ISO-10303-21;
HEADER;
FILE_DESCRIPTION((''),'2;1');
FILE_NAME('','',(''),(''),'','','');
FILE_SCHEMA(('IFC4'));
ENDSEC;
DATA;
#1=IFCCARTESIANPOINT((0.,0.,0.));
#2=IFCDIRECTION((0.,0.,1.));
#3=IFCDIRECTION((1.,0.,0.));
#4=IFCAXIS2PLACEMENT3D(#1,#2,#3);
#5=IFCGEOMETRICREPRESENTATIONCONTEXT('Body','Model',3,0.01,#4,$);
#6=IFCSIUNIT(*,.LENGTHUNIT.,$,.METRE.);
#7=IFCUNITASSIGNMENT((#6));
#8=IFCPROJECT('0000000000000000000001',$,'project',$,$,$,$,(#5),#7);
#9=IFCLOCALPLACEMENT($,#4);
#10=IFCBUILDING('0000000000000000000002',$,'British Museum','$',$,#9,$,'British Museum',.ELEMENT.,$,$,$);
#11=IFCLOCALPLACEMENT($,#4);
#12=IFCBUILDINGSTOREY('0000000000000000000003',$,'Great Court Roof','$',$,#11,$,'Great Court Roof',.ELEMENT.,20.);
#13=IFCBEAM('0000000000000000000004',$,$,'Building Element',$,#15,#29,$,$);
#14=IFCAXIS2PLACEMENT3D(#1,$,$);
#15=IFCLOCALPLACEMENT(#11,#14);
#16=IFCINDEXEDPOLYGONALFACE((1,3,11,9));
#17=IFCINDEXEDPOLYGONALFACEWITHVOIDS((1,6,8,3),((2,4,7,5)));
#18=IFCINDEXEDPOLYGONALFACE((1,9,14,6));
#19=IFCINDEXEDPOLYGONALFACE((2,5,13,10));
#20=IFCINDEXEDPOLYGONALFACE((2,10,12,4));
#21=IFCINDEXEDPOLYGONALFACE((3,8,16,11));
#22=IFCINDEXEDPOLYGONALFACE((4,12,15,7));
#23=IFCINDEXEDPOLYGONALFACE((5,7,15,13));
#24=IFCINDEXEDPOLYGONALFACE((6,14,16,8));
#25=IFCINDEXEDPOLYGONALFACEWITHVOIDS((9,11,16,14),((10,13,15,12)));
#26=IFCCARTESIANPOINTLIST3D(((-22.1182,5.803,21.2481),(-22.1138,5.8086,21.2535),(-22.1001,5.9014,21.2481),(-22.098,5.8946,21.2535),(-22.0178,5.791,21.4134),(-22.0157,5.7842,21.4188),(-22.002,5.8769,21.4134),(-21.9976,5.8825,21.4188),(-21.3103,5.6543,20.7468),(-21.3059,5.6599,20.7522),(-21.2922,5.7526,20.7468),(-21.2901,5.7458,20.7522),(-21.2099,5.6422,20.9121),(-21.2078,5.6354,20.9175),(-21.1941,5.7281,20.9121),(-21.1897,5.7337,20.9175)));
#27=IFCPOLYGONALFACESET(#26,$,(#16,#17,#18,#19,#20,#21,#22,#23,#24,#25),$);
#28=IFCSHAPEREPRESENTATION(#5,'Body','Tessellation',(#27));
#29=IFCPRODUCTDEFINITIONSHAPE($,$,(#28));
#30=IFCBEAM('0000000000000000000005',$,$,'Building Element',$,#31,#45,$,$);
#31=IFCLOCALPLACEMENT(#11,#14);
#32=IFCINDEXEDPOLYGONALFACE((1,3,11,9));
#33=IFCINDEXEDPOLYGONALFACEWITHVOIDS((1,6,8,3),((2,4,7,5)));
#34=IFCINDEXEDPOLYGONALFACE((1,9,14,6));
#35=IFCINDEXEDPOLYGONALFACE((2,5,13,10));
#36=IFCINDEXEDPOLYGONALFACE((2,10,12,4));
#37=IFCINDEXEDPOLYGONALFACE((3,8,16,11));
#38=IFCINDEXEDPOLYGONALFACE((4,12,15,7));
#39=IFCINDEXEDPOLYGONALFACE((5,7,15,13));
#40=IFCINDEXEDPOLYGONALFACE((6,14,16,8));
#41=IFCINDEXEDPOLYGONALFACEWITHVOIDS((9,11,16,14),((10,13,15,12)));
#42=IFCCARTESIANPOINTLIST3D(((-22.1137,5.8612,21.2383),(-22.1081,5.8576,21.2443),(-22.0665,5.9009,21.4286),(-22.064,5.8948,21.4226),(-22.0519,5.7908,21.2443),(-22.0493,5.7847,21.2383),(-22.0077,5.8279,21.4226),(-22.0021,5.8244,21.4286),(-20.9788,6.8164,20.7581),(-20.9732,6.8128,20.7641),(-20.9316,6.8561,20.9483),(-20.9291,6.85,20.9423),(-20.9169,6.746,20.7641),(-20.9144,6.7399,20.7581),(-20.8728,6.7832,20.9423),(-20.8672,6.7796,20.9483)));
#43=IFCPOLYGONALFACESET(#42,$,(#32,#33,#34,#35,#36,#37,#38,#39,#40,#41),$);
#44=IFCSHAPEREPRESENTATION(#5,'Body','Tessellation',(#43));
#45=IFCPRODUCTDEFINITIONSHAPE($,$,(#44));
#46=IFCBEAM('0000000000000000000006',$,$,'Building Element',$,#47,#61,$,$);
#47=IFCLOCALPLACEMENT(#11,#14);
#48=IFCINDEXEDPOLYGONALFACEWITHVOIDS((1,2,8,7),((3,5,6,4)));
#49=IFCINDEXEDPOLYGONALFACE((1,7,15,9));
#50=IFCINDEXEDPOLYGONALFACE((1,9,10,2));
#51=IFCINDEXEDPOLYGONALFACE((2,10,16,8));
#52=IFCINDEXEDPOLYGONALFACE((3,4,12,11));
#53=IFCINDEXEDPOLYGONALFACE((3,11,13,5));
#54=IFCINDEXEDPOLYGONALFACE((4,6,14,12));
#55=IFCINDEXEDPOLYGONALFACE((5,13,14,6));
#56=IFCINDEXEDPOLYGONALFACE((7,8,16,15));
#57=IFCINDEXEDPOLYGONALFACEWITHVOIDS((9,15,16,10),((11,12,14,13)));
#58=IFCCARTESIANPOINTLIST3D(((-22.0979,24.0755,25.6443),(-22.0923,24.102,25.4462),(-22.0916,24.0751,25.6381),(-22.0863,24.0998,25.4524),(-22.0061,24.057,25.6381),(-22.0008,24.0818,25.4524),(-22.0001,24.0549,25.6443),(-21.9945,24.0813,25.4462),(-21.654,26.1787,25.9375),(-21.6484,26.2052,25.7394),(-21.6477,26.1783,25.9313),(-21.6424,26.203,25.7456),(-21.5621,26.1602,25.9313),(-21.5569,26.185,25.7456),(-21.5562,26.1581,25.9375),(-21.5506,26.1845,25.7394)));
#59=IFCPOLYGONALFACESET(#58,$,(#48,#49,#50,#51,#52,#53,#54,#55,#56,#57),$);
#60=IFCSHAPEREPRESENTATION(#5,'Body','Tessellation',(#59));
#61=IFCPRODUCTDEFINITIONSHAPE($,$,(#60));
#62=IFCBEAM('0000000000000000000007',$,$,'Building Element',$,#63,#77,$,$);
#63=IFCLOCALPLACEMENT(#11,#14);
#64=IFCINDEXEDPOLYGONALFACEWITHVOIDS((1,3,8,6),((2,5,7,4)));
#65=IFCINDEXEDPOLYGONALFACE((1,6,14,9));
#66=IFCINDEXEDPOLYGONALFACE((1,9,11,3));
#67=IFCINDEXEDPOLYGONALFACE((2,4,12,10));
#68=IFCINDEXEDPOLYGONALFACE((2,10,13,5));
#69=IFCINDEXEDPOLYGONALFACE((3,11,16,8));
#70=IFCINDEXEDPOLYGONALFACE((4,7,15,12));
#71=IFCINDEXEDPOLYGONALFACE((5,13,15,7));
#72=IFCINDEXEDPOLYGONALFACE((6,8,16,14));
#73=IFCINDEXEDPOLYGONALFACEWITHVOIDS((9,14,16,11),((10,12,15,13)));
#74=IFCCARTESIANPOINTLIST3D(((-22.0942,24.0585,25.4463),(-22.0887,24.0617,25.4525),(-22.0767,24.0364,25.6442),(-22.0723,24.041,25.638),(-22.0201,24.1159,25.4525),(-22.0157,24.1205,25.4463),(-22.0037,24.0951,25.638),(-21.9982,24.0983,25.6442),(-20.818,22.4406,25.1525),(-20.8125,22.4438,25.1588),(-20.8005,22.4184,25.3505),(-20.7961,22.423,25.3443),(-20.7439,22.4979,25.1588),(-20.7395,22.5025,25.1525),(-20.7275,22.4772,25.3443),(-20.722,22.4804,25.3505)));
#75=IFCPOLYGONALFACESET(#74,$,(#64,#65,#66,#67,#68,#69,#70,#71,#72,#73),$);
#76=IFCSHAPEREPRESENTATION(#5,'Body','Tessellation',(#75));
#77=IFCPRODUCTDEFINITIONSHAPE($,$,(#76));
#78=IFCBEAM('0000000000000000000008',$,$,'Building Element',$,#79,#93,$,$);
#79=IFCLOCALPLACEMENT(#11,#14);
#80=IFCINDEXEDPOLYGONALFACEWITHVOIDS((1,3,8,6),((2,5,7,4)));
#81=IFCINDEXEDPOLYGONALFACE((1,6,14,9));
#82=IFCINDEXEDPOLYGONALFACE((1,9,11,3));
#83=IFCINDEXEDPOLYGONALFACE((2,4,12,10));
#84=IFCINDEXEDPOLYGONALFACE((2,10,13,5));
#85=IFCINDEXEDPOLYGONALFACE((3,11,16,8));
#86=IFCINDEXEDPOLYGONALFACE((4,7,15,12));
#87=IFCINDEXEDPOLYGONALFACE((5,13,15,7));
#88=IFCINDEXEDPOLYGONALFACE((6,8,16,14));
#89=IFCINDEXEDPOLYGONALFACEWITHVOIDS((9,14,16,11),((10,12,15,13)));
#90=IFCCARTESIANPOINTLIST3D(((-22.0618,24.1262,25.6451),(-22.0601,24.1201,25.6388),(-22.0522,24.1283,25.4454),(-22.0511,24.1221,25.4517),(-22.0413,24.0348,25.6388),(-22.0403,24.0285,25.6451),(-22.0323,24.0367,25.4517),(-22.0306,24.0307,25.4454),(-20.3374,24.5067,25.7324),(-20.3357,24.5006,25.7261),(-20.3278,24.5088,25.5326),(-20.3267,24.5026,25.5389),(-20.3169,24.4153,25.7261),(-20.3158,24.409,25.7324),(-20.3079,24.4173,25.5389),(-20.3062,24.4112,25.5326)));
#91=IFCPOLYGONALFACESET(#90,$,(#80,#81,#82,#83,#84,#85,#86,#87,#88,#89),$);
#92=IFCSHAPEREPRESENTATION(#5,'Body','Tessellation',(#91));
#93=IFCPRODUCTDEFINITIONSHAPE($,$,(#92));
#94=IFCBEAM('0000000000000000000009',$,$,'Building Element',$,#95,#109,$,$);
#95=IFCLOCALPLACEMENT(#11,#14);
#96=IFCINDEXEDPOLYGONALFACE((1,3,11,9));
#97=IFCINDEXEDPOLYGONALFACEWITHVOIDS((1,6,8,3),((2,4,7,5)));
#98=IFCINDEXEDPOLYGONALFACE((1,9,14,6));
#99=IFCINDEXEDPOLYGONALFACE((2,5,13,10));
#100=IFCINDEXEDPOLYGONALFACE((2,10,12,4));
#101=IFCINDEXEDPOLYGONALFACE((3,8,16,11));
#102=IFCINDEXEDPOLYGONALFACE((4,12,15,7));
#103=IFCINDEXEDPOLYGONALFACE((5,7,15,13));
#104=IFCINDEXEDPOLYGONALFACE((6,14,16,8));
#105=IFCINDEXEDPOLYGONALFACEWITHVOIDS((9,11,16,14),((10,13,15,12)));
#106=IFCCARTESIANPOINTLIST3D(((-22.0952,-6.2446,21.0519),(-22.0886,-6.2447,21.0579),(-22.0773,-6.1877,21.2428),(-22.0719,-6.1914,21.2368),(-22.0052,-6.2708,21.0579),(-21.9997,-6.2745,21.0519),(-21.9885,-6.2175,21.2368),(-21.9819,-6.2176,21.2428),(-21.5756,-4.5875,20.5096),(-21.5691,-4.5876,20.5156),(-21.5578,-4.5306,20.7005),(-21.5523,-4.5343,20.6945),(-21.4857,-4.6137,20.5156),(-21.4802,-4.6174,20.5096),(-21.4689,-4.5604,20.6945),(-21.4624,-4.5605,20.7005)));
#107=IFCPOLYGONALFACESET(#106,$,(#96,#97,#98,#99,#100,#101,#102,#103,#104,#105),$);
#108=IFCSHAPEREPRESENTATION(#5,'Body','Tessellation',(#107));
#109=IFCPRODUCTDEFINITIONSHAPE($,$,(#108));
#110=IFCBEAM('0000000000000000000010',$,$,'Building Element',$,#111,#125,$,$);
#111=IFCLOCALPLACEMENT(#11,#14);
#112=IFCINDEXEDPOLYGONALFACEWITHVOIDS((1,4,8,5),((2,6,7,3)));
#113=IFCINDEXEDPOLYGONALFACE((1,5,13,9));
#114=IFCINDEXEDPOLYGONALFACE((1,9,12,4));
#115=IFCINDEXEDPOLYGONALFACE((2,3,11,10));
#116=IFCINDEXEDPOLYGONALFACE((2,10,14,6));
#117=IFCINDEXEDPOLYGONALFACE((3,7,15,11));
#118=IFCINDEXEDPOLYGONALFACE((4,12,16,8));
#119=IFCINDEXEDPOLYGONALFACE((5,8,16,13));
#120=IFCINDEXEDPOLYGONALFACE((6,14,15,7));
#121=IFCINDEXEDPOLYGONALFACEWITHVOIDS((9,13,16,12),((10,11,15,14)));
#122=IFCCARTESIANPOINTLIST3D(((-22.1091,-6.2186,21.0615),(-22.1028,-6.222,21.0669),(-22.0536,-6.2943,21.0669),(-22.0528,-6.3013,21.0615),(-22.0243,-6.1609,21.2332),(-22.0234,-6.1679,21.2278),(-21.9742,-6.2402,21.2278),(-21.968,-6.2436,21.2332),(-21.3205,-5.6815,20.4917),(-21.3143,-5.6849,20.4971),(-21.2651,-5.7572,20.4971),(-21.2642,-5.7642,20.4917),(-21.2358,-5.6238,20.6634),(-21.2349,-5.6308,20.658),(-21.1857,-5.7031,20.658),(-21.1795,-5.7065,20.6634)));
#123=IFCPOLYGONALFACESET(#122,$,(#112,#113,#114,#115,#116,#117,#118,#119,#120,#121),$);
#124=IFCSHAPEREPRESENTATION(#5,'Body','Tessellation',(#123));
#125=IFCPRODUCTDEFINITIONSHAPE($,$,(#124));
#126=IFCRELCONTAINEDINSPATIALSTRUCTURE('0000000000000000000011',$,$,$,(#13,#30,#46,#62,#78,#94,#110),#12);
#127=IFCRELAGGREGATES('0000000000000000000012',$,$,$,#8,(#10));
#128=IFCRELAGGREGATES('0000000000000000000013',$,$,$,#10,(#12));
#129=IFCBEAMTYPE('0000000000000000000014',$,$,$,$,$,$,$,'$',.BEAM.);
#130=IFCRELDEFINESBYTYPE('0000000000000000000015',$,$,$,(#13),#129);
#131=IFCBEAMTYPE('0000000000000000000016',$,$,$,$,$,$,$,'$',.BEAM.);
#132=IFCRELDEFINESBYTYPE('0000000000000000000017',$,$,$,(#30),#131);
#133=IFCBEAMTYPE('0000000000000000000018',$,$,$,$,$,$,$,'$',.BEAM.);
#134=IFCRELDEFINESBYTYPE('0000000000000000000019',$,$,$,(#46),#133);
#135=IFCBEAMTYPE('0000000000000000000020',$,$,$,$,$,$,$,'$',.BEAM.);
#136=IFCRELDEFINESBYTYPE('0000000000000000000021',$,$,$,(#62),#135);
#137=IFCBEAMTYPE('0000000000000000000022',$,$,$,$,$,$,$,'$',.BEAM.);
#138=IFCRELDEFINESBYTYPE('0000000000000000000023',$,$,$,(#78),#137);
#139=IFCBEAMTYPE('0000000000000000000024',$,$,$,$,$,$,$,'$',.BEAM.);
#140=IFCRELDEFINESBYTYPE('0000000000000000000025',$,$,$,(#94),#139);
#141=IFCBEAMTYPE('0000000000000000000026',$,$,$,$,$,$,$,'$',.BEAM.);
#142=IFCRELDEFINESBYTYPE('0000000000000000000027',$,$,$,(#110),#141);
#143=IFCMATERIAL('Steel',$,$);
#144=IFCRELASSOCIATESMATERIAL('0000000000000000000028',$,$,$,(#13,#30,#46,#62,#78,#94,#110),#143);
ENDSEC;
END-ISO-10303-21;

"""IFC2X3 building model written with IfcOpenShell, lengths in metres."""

from ifc_helpers import new_model, si_unit, frame, origin_with_axes, origin_2d, place, context, project, spatial, hollow_rectangle, extrude, material, type_object, element, save


model = new_model("IFC2X3")

# Units and contexts
model_context = context("Model", 3, precision=0.01, world=origin_with_axes(), identifier="Body")
ifc_project = project(units=[si_unit("LENGTHUNIT", "METRE")], contexts=[model_context])

# Building, storey
building_placement = place(None, origin_with_axes())
building = spatial("IfcBuilding", under=ifc_project, at=building_placement, Name="British Museum", Description="$", LongName="British Museum", CompositionType="ELEMENT")
storey_placement = place(None, origin_with_axes())
storey = spatial("IfcBuildingStorey", under=building, at=storey_placement, Name="Great Court Roof", Description="$", LongName="Great Court Roof", CompositionType="ELEMENT", Elevation=20.0)

# Beams
ifc_material = material(Name="Steel")
beam_type_1 = type_object("IfcBeamType", ElementType="$", PredefinedType="BEAM")
beam_1_placement = place(None, origin_with_axes())
element("IfcBeam", 1, at=beam_1_placement, inside=storey, type_object=beam_type_1, material=ifc_material, Description="Building Element", context=model_context, shape_type="SweptSolid", body=[
    extrude(hollow_rectangle(XDim=0.1, YDim=0.2, WallThickness=0.0063, InnerFilletRadius=0.0, OuterFilletRadius=0.0, at=origin_2d()), frame((-22.0579, 5.8428, 21.3335), z_axis=(0.839501, -0.154601, -0.5209), x_axis=(0.181113, 0.983462, 0.0)), (0.0, 0.0, 1.0), 0.9624),
])
beam_type_2 = type_object("IfcBeamType", ElementType="$", PredefinedType="BEAM")
beam_2_placement = place(None, origin_with_axes())
element("IfcBeam", 2, at=beam_2_placement, inside=storey, type_object=beam_type_2, material=ifc_material, Description="Building Element", context=model_context, shape_type="SweptSolid", body=[
    extrude(hollow_rectangle(XDim=0.1, YDim=0.2, WallThickness=0.0063, InnerFilletRadius=0.0, OuterFilletRadius=0.0, at=origin_2d()), frame((-22.0579, 5.8428, 21.3335), z_axis=(0.727878, 0.612632, -0.30802), x_axis=(-0.64394, 0.765076, 0.0)), (0.0, 0.0, 1.0), 1.5592),
])
beam_type_3 = type_object("IfcBeamType", ElementType="$", PredefinedType="BEAM")
beam_3_placement = place(None, origin_with_axes())
element("IfcBeam", 3, at=beam_3_placement, inside=storey, type_object=beam_type_3, material=ifc_material, Description="Building Element", context=model_context, shape_type="SweptSolid", body=[
    extrude(hollow_rectangle(XDim=0.1, YDim=0.2, WallThickness=0.0063, InnerFilletRadius=0.0, OuterFilletRadius=0.0, at=origin_2d()), frame((-22.0462, 24.0784, 25.5452), z_axis=(0.204625, 0.969465, 0.135154), x_axis=(-0.978442, 0.20652, 0.0)), (0.0, 0.0, 1.0), 2.1694),
])
beam_type_4 = type_object("IfcBeamType", ElementType="$", PredefinedType="BEAM")
beam_4_placement = place(None, origin_with_axes())
element("IfcBeam", 4, at=beam_4_placement, inside=storey, type_object=beam_type_4, material=ifc_material, Description="Building Element", context=model_context, shape_type="SweptSolid", body=[
    extrude(hollow_rectangle(XDim=0.1, YDim=0.2, WallThickness=0.0063, InnerFilletRadius=0.0, OuterFilletRadius=0.0, at=origin_2d()), frame((-22.0462, 24.0784, 25.5452), z_axis=(0.613107, -0.777294, -0.141117), x_axis=(0.785151, 0.619305, 0.0)), (0.0, 0.0, 1.0), 2.0815),
])
beam_type_5 = type_object("IfcBeamType", ElementType="$", PredefinedType="BEAM")
beam_5_placement = place(None, origin_with_axes())
element("IfcBeam", 5, at=beam_5_placement, inside=storey, type_object=beam_type_5, material=ifc_material, Description="Building Element", context=model_context, shape_type="SweptSolid", body=[
    extrude(hollow_rectangle(XDim=0.1, YDim=0.2, WallThickness=0.0063, InnerFilletRadius=0.0, OuterFilletRadius=0.0, at=origin_2d()), frame((-22.0462, 24.0784, 25.5452), z_axis=(0.975319, 0.215215, 0.049353), x_axis=(-0.215478, 0.976509, 0.0)), (0.0, 0.0, 1.0), 1.768),
])
beam_type_6 = type_object("IfcBeamType", ElementType="$", PredefinedType="BEAM")
beam_6_placement = place(None, origin_with_axes())
element("IfcBeam", 6, at=beam_6_placement, inside=storey, type_object=beam_type_6, material=ifc_material, Description="Building Element", context=model_context, shape_type="SweptSolid", body=[
    extrude(hollow_rectangle(XDim=0.1, YDim=0.2, WallThickness=0.0063, InnerFilletRadius=0.0, OuterFilletRadius=0.0, at=origin_2d()), frame((-22.0385, -6.2311, 21.1473), z_axis=(0.285566, 0.910831, -0.298059), x_axis=(-0.954202, 0.299164, 0.0)), (0.0, 0.0, 1.0), 1.8193),
])
beam_type_7 = type_object("IfcBeamType", ElementType="$", PredefinedType="BEAM")
beam_7_placement = place(None, origin_with_axes())
element("IfcBeam", 7, at=beam_7_placement, inside=storey, type_object=beam_type_7, material=ifc_material, Description="Building Element", context=model_context, shape_type="SweptSolid", body=[
    extrude(hollow_rectangle(XDim=0.1, YDim=0.2, WallThickness=0.0063, InnerFilletRadius=0.0, OuterFilletRadius=0.0, at=origin_2d()), frame((-22.0385, -6.2311, 21.1473), z_axis=(0.709573, 0.483319, -0.512746), x_axis=(-0.562955, 0.826488, 0.0)), (0.0, 0.0, 1.0), 1.1113),
])

save(model, "model.ifc")
